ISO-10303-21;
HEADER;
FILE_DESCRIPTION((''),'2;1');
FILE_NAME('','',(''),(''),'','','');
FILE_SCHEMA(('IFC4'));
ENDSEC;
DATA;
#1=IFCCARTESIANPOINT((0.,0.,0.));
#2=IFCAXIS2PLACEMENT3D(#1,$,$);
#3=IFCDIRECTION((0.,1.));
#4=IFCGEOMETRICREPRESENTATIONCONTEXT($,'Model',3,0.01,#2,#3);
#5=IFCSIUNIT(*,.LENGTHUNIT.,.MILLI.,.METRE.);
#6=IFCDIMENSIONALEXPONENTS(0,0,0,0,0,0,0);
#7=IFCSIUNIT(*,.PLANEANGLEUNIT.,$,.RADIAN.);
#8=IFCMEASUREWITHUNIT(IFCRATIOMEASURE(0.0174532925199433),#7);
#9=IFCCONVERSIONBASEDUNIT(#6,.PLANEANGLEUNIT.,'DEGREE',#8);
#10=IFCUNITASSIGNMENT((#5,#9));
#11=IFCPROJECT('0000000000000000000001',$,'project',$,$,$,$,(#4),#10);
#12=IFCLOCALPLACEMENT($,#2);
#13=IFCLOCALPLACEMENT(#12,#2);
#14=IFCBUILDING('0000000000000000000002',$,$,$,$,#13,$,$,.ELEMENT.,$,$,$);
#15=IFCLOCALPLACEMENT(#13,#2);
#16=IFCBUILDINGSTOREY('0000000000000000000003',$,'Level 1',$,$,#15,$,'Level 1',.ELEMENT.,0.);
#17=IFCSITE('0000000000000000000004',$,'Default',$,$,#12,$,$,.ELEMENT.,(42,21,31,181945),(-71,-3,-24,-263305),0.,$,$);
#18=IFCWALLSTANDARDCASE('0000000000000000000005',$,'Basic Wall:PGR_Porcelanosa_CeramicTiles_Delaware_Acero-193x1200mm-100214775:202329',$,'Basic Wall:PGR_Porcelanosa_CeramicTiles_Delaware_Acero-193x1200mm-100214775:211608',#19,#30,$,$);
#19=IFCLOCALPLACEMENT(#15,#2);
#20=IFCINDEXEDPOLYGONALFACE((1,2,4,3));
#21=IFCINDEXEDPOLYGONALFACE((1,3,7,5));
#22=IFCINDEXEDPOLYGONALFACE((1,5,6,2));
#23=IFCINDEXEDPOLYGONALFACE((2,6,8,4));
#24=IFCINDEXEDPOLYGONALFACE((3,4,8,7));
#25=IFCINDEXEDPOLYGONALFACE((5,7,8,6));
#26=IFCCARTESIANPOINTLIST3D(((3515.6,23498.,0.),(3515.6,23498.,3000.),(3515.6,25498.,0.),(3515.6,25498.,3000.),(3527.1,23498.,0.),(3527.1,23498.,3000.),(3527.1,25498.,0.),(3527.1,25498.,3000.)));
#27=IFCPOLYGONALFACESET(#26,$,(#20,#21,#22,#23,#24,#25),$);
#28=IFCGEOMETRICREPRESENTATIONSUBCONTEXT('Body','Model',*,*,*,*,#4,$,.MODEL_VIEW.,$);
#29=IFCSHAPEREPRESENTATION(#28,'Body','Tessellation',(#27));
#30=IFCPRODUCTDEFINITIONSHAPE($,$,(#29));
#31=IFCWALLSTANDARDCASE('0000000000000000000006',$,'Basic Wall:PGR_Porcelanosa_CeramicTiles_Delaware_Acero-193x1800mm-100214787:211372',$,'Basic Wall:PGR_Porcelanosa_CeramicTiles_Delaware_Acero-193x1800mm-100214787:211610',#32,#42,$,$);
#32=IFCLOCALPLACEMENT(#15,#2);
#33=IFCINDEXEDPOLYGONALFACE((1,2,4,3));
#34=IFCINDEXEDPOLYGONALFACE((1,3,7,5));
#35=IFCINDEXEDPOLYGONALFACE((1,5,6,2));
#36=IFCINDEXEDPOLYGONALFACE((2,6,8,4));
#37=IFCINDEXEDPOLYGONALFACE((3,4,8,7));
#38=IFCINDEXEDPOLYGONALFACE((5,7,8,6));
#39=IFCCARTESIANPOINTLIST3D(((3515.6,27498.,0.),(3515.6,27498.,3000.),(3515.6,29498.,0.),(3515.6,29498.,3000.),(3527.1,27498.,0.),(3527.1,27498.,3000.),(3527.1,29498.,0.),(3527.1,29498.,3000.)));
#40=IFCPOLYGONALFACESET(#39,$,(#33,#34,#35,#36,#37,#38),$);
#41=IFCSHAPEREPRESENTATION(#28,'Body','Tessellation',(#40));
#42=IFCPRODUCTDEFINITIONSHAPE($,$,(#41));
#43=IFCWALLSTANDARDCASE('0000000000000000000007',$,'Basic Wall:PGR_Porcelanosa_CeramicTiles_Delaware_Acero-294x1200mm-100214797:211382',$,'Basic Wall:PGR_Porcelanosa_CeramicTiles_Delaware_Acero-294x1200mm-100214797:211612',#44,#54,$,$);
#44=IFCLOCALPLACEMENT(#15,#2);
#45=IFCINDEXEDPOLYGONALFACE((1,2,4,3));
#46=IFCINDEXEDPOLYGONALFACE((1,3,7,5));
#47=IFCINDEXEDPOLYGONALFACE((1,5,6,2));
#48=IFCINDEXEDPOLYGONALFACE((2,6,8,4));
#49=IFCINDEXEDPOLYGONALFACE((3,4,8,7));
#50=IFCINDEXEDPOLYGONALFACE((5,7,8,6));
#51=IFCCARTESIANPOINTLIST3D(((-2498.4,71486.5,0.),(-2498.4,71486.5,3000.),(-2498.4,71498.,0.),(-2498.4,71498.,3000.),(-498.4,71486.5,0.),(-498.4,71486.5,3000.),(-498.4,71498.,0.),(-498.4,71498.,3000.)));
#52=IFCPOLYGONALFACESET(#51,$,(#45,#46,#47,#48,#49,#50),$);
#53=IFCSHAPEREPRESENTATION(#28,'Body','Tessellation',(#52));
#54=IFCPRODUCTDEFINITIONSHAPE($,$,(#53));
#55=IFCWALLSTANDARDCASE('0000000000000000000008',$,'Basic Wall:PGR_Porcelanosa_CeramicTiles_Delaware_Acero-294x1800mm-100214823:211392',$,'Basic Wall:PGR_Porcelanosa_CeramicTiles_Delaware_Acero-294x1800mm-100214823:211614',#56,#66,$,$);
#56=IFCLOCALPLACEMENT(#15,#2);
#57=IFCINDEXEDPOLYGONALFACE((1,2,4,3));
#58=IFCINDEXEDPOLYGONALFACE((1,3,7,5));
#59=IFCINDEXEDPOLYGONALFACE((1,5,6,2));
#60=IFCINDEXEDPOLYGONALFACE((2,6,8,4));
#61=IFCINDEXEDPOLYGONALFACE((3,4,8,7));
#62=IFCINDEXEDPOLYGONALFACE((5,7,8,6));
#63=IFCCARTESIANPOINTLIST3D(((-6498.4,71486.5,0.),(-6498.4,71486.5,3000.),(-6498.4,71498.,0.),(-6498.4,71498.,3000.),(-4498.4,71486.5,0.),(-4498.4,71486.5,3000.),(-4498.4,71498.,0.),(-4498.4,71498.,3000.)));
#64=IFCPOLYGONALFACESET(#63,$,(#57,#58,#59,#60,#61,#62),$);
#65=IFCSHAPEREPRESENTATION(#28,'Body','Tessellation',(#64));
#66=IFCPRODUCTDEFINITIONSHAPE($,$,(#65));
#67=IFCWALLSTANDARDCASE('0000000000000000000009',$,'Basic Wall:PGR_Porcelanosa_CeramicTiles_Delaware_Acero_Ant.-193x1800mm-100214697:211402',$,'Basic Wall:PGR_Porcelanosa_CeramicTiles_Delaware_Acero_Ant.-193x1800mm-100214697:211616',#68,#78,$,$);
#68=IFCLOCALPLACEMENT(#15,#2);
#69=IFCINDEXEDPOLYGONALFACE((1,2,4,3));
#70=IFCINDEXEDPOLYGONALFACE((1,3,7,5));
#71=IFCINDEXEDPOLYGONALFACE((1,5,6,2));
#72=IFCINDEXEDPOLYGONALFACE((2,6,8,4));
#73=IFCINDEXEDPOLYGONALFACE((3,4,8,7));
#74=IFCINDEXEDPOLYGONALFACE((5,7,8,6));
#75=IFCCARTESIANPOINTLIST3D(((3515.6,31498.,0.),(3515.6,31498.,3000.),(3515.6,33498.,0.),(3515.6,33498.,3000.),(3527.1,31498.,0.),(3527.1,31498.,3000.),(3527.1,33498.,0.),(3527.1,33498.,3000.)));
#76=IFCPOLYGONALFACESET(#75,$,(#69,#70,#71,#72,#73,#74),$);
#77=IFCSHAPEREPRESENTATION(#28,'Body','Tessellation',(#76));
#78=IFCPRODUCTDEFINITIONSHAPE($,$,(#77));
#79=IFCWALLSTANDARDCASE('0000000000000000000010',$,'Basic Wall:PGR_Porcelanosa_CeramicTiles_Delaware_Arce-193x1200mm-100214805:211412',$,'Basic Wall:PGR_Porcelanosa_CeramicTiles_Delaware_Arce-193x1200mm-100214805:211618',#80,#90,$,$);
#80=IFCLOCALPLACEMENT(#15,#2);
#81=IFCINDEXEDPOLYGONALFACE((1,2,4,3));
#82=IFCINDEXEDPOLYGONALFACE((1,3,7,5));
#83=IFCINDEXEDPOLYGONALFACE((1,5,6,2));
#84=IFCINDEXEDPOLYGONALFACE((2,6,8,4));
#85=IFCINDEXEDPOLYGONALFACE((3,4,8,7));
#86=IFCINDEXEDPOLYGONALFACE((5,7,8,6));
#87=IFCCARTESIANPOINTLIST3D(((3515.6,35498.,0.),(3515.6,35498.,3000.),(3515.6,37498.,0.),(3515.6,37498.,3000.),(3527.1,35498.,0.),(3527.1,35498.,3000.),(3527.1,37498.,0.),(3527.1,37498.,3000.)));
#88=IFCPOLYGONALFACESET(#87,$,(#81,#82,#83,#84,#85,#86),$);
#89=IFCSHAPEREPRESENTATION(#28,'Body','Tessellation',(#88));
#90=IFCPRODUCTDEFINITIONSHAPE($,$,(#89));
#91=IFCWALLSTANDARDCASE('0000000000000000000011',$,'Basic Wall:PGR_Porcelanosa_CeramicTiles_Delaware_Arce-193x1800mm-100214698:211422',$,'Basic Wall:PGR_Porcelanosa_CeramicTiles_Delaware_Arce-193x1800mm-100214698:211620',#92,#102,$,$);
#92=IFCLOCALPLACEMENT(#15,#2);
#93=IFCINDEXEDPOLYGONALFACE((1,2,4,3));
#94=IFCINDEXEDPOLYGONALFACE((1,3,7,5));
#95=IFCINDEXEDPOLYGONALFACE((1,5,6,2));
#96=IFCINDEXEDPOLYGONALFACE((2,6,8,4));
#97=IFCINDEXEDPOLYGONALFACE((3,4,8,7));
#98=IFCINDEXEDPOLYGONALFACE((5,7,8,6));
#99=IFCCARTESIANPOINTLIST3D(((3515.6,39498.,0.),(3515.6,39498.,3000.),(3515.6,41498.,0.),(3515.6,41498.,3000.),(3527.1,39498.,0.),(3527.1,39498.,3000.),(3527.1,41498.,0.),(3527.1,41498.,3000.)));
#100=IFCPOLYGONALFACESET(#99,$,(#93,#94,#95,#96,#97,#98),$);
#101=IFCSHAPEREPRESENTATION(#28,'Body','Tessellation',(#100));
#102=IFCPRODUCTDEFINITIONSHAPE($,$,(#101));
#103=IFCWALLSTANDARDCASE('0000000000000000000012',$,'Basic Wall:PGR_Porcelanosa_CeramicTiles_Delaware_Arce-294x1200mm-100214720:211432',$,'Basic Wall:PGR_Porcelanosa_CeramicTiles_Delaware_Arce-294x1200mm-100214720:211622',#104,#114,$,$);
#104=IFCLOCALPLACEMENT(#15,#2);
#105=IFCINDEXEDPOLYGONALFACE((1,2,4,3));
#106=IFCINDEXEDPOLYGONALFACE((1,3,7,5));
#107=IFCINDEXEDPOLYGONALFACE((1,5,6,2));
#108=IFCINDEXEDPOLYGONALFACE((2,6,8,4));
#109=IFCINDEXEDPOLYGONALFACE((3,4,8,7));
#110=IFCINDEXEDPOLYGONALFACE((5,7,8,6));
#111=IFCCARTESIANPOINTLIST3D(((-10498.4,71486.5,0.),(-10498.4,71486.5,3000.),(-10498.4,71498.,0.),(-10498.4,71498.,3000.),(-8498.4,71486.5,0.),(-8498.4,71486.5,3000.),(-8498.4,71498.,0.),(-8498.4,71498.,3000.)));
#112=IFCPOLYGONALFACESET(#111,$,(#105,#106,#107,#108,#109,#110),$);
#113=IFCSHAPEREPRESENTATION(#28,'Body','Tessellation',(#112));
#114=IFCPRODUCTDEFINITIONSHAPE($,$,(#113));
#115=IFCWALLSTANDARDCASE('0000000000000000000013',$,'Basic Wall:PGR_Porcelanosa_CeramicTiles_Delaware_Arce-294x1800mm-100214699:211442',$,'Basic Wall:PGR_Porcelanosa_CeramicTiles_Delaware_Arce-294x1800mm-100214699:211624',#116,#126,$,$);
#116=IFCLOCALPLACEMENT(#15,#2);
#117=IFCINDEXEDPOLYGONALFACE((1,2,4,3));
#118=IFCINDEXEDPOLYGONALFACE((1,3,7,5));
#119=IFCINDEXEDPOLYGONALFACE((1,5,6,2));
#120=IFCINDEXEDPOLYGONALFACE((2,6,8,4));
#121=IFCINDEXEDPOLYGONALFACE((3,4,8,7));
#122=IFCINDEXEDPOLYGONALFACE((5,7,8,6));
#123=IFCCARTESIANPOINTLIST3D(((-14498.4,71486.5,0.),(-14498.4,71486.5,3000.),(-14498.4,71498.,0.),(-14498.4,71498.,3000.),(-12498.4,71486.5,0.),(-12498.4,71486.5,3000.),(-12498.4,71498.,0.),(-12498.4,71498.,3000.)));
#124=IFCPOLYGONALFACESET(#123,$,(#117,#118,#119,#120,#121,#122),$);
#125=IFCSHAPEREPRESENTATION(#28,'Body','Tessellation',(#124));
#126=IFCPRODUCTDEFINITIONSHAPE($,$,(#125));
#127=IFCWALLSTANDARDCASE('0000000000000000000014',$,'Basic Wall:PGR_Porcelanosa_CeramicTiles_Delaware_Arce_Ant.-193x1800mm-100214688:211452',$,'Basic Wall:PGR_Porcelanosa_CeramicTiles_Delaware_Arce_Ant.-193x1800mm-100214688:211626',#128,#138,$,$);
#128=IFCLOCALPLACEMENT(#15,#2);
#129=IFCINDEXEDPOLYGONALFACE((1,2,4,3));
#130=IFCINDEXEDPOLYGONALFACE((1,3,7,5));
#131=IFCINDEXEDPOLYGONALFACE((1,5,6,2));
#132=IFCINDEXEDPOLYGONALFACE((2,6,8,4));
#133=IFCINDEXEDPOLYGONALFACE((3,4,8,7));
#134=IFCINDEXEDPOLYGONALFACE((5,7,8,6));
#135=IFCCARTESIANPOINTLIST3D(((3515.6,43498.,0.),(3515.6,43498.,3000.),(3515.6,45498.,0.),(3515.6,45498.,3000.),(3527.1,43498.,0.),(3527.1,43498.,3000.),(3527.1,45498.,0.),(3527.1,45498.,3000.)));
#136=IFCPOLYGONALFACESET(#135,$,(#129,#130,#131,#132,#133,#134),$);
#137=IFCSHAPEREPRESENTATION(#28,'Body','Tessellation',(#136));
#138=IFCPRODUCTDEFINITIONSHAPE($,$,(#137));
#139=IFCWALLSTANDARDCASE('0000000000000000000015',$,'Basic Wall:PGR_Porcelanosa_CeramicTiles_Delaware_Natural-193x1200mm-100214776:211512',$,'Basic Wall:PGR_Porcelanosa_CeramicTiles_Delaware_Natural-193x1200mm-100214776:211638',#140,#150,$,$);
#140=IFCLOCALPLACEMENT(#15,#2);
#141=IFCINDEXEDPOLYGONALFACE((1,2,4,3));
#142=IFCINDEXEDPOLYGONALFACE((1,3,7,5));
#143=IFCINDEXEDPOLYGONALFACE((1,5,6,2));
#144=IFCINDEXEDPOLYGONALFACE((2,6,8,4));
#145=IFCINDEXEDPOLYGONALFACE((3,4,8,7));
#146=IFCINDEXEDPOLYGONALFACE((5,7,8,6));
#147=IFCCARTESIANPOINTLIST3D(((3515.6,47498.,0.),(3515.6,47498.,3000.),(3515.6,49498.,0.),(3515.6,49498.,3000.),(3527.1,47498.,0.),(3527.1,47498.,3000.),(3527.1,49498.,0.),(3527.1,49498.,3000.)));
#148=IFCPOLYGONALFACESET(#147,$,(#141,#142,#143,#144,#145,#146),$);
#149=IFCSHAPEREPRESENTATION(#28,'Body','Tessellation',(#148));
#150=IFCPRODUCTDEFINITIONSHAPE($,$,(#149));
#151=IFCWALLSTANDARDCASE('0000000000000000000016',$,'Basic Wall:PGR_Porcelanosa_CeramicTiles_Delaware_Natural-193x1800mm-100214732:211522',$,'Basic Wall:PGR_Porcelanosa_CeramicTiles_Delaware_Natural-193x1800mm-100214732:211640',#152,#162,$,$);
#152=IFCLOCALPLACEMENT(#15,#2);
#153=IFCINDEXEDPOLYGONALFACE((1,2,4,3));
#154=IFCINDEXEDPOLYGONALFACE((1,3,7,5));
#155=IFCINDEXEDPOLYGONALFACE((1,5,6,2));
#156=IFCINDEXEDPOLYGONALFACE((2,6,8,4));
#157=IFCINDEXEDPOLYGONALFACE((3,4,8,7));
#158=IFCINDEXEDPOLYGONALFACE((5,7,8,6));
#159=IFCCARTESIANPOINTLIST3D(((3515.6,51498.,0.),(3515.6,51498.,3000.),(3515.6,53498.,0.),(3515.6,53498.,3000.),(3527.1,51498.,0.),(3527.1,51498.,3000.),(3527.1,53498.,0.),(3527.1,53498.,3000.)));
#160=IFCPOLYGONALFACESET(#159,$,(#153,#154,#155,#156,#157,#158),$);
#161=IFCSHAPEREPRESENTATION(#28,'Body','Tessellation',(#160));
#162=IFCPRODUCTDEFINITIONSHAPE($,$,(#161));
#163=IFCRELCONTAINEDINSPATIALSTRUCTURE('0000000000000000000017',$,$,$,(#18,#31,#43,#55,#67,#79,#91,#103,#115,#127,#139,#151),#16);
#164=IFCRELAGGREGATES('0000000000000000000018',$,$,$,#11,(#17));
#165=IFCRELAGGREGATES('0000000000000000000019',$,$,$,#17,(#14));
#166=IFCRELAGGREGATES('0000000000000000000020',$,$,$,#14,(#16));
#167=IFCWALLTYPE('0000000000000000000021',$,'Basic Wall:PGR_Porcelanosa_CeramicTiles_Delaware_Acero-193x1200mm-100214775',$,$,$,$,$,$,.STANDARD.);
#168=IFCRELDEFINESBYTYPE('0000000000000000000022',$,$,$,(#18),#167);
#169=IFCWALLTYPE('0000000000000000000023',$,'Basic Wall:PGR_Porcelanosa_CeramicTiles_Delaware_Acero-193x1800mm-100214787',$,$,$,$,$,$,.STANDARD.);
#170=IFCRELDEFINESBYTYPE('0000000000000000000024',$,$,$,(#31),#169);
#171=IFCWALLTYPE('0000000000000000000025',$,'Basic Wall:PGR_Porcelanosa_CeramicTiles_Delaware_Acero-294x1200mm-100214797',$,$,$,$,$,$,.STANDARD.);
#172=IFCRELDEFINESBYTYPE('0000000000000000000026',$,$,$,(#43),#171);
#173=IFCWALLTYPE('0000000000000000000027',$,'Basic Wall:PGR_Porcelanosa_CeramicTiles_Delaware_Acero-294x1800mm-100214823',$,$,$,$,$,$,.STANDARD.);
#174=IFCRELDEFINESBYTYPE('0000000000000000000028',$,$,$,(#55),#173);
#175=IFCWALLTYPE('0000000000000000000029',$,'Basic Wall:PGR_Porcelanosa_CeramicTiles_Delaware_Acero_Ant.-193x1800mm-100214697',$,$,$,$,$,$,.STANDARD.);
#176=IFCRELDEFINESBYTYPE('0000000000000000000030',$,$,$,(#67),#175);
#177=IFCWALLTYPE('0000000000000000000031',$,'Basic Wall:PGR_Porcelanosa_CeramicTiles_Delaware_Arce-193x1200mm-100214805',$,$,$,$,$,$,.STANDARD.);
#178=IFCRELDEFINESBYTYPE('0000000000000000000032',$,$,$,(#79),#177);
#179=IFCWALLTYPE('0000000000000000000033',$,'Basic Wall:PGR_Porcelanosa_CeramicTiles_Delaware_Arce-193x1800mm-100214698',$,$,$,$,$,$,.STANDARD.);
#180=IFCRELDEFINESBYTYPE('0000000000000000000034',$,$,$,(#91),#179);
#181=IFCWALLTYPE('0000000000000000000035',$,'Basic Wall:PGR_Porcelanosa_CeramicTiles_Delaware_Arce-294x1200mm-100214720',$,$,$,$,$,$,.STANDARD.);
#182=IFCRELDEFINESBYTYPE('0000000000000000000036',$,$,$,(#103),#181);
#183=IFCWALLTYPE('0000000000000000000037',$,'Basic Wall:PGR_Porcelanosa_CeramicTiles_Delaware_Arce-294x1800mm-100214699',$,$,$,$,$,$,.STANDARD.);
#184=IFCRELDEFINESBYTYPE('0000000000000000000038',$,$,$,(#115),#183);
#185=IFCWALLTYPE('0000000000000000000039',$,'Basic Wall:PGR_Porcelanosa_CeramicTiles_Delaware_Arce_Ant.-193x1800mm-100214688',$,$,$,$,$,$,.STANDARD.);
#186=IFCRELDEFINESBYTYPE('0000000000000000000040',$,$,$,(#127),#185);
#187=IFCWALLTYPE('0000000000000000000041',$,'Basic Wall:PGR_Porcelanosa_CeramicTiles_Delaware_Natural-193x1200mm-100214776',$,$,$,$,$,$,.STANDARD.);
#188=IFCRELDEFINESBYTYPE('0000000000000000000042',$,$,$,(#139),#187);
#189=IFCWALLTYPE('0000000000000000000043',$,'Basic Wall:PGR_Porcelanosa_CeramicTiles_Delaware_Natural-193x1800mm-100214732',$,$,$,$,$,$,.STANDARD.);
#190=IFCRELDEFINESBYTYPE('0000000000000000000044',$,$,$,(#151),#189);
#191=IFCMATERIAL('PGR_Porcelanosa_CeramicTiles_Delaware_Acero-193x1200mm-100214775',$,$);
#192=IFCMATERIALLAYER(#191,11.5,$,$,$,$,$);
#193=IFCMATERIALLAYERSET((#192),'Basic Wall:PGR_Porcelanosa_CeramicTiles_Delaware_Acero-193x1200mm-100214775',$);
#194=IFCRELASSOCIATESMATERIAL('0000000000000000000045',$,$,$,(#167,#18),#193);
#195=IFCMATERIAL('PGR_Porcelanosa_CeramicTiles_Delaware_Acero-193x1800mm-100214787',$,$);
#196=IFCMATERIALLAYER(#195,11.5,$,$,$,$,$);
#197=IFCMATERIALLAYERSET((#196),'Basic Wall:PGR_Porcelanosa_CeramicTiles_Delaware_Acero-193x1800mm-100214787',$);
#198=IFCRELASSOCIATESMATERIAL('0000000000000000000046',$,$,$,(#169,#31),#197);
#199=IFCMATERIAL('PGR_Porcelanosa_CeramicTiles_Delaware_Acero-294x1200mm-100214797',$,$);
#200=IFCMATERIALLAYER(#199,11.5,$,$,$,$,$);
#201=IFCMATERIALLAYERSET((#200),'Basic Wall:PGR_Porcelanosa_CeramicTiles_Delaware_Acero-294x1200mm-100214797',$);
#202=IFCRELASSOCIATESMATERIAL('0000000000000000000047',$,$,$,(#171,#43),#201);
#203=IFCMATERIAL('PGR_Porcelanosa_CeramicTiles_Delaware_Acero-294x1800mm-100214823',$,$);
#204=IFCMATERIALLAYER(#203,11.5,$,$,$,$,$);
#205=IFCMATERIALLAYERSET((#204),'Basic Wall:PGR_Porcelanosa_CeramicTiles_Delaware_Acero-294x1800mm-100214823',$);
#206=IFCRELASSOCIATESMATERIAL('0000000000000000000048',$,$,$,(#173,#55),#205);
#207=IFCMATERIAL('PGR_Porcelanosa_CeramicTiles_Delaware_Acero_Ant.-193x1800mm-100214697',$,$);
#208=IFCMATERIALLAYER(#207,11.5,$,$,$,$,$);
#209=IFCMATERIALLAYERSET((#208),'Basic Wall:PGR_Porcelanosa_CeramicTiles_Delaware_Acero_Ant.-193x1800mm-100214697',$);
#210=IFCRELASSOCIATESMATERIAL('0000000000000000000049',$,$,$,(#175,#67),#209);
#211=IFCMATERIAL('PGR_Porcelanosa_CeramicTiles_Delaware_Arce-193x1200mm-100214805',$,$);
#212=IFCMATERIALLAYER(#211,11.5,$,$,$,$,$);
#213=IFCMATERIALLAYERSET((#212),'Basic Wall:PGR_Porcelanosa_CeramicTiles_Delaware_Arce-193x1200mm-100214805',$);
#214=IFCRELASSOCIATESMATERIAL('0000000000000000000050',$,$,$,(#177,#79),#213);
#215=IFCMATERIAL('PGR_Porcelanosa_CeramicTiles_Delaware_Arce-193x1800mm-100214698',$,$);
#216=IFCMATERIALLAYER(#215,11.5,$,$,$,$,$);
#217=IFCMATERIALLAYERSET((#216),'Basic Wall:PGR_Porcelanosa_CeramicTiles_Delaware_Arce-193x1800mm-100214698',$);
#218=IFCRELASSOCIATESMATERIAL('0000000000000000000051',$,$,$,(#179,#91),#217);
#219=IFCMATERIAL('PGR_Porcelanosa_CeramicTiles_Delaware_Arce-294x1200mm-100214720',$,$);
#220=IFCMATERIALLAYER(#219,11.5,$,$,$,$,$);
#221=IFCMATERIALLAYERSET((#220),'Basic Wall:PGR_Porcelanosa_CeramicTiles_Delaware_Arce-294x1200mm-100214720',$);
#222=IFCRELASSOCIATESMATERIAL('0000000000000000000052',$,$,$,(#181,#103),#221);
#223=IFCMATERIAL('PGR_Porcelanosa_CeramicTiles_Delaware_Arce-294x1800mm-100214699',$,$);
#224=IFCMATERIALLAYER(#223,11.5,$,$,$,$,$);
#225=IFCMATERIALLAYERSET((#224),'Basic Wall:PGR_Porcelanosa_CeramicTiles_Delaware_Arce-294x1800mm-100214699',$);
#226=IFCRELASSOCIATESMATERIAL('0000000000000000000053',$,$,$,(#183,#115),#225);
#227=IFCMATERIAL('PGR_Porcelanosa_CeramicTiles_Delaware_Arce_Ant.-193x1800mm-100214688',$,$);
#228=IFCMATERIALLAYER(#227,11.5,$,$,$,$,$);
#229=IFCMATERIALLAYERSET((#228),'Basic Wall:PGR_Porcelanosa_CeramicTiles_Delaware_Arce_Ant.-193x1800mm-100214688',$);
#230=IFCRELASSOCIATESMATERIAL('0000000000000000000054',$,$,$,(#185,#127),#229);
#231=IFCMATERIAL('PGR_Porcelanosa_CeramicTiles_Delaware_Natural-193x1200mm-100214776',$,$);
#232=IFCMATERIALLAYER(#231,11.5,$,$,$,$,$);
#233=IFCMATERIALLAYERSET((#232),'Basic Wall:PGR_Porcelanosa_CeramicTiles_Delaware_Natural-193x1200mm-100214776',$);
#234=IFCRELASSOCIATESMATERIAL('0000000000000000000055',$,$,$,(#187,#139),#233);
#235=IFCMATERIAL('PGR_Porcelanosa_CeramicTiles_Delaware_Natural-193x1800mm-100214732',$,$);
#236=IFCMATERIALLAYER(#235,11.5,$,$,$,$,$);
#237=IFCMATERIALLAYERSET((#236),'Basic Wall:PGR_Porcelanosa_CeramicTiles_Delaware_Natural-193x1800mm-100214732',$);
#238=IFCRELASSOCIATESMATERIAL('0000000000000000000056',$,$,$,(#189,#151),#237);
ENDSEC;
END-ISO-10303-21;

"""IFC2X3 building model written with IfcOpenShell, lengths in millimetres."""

from ifc_helpers import new_model, entity, si_unit, converted_unit, direction, frame, frame_2d, origin, place, context, subcontext, project, spatial, rectangle, extrude, material, layer, layer_set, layer_usage, type_object, element, save


model = new_model("IFC2X3")

# Units and contexts
model_context = context("Model", 3, precision=0.01, world=origin(), true_north=direction((0.0, 1.0)))
body_context = subcontext(model_context, "Body", "Model", "MODEL_VIEW")
ifc_project = project(units=[si_unit("LENGTHUNIT", "METRE", prefix="MILLI"), converted_unit("PLANEANGLEUNIT", "DEGREE", entity("IfcRatioMeasure", 0.0174532925199433), si_unit("PLANEANGLEUNIT", "RADIAN"), dimensions=[0, 0, 0, 0, 0, 0, 0])], contexts=[model_context])

# Site, building, storey
site_placement = place(None, origin())
site = spatial("IfcSite", under=ifc_project, at=site_placement, Name="Default", CompositionType="ELEMENT", RefLatitude=(42, 21, 31, 181945), RefLongitude=(-71, -3, -24, -263305), RefElevation=0.0)
building_placement = place(site_placement, origin())
building = spatial("IfcBuilding", under=site, at=building_placement, CompositionType="ELEMENT")
storey_placement = place(building_placement, origin())
storey = spatial("IfcBuildingStorey", under=building, at=storey_placement, Name="Level 1", LongName="Level 1", CompositionType="ELEMENT", Elevation=0.0)

# Walls
ifc_material_1 = material(Name="PGR_Porcelanosa_CeramicTiles_Delaware_Acero-193x1200mm-100214775")
ifc_layer_1 = layer(ifc_material_1, 11.5)
ifc_layer_set_1 = layer_set([ifc_layer_1], Name="Basic Wall:PGR_Porcelanosa_CeramicTiles_Delaware_Acero-193x1200mm-100214775")
ifc_layer_usage_1 = layer_usage(ifc_layer_set_1, "AXIS2", "POSITIVE", -5.8)
wall_type_1 = type_object("IfcWallType", Name="Basic Wall:PGR_Porcelanosa_CeramicTiles_Delaware_Acero-193x1200mm-100214775", PredefinedType="STANDARD", material=ifc_layer_set_1)
wall_1_placement = place(storey_placement, frame((3521.3, 25498.0, 0.0), z_axis=(0.0, 0.0, 1.0), x_axis=(0.0, -1.0, 0.0)))
element("IfcWallStandardCase", 1, at=wall_1_placement, inside=storey, type_object=wall_type_1, material=ifc_layer_usage_1, Name="Basic Wall:PGR_Porcelanosa_CeramicTiles_Delaware_Acero-193x1200mm-100214775:202329", ObjectType="Basic Wall:PGR_Porcelanosa_CeramicTiles_Delaware_Acero-193x1200mm-100214775:211608", context=body_context, shape_type="SweptSolid", body=[
    extrude(rectangle(XDim=2000.0, YDim=11.5, at=frame_2d((1000.0, 0.0), x_axis=(-1.0, 0.0))), origin(), (0.0, 0.0, 1.0), 3000.0),
])
ifc_material_2 = material(Name="PGR_Porcelanosa_CeramicTiles_Delaware_Acero-193x1800mm-100214787")
ifc_layer_2 = layer(ifc_material_2, 11.5)
ifc_layer_set_2 = layer_set([ifc_layer_2], Name="Basic Wall:PGR_Porcelanosa_CeramicTiles_Delaware_Acero-193x1800mm-100214787")
ifc_layer_usage_2 = layer_usage(ifc_layer_set_2, "AXIS2", "POSITIVE", -5.8)
wall_type_2 = type_object("IfcWallType", Name="Basic Wall:PGR_Porcelanosa_CeramicTiles_Delaware_Acero-193x1800mm-100214787", PredefinedType="STANDARD", material=ifc_layer_set_2)
wall_2_placement = place(storey_placement, frame((3521.3, 29498.0, 0.0), z_axis=(0.0, 0.0, 1.0), x_axis=(0.0, -1.0, 0.0)))
element("IfcWallStandardCase", 2, at=wall_2_placement, inside=storey, type_object=wall_type_2, material=ifc_layer_usage_2, Name="Basic Wall:PGR_Porcelanosa_CeramicTiles_Delaware_Acero-193x1800mm-100214787:211372", ObjectType="Basic Wall:PGR_Porcelanosa_CeramicTiles_Delaware_Acero-193x1800mm-100214787:211610", context=body_context, shape_type="SweptSolid", body=[
    extrude(rectangle(XDim=2000.0, YDim=11.5, at=frame_2d((1000.0, 0.0), x_axis=(-1.0, 0.0))), origin(), (0.0, 0.0, 1.0), 3000.0),
])
ifc_material_3 = material(Name="PGR_Porcelanosa_CeramicTiles_Delaware_Acero-294x1200mm-100214797")
ifc_layer_3 = layer(ifc_material_3, 11.5)
ifc_layer_set_3 = layer_set([ifc_layer_3], Name="Basic Wall:PGR_Porcelanosa_CeramicTiles_Delaware_Acero-294x1200mm-100214797")
ifc_layer_usage_3 = layer_usage(ifc_layer_set_3, "AXIS2", "POSITIVE", -5.8)
wall_type_3 = type_object("IfcWallType", Name="Basic Wall:PGR_Porcelanosa_CeramicTiles_Delaware_Acero-294x1200mm-100214797", PredefinedType="STANDARD", material=ifc_layer_set_3)
wall_3_placement = place(storey_placement, frame((-2498.4, 71492.3, 0.0)))
element("IfcWallStandardCase", 3, at=wall_3_placement, inside=storey, type_object=wall_type_3, material=ifc_layer_usage_3, Name="Basic Wall:PGR_Porcelanosa_CeramicTiles_Delaware_Acero-294x1200mm-100214797:211382", ObjectType="Basic Wall:PGR_Porcelanosa_CeramicTiles_Delaware_Acero-294x1200mm-100214797:211612", context=body_context, shape_type="SweptSolid", body=[
    extrude(rectangle(XDim=2000.0, YDim=11.5, at=frame_2d((1000.0, 0.0), x_axis=(-1.0, 0.0))), origin(), (0.0, 0.0, 1.0), 3000.0),
])
ifc_material_4 = material(Name="PGR_Porcelanosa_CeramicTiles_Delaware_Acero-294x1800mm-100214823")
ifc_layer_4 = layer(ifc_material_4, 11.5)
ifc_layer_set_4 = layer_set([ifc_layer_4], Name="Basic Wall:PGR_Porcelanosa_CeramicTiles_Delaware_Acero-294x1800mm-100214823")
ifc_layer_usage_4 = layer_usage(ifc_layer_set_4, "AXIS2", "POSITIVE", -5.8)
wall_type_4 = type_object("IfcWallType", Name="Basic Wall:PGR_Porcelanosa_CeramicTiles_Delaware_Acero-294x1800mm-100214823", PredefinedType="STANDARD", material=ifc_layer_set_4)
wall_4_placement = place(storey_placement, frame((-6498.4, 71492.3, 0.0)))
element("IfcWallStandardCase", 4, at=wall_4_placement, inside=storey, type_object=wall_type_4, material=ifc_layer_usage_4, Name="Basic Wall:PGR_Porcelanosa_CeramicTiles_Delaware_Acero-294x1800mm-100214823:211392", ObjectType="Basic Wall:PGR_Porcelanosa_CeramicTiles_Delaware_Acero-294x1800mm-100214823:211614", context=body_context, shape_type="SweptSolid", body=[
    extrude(rectangle(XDim=2000.0, YDim=11.5, at=frame_2d((1000.0, 0.0), x_axis=(-1.0, 0.0))), origin(), (0.0, 0.0, 1.0), 3000.0),
])
ifc_material_5 = material(Name="PGR_Porcelanosa_CeramicTiles_Delaware_Acero_Ant.-193x1800mm-100214697")
ifc_layer_5 = layer(ifc_material_5, 11.5)
ifc_layer_set_5 = layer_set([ifc_layer_5], Name="Basic Wall:PGR_Porcelanosa_CeramicTiles_Delaware_Acero_Ant.-193x1800mm-100214697")
ifc_layer_usage_5 = layer_usage(ifc_layer_set_5, "AXIS2", "POSITIVE", -5.8)
wall_type_5 = type_object("IfcWallType", Name="Basic Wall:PGR_Porcelanosa_CeramicTiles_Delaware_Acero_Ant.-193x1800mm-100214697", PredefinedType="STANDARD", material=ifc_layer_set_5)
wall_5_placement = place(storey_placement, frame((3521.3, 33498.0, 0.0), z_axis=(0.0, 0.0, 1.0), x_axis=(0.0, -1.0, 0.0)))
element("IfcWallStandardCase", 5, at=wall_5_placement, inside=storey, type_object=wall_type_5, material=ifc_layer_usage_5, Name="Basic Wall:PGR_Porcelanosa_CeramicTiles_Delaware_Acero_Ant.-193x1800mm-100214697:211402", ObjectType="Basic Wall:PGR_Porcelanosa_CeramicTiles_Delaware_Acero_Ant.-193x1800mm-100214697:211616", context=body_context, shape_type="SweptSolid", body=[
    extrude(rectangle(XDim=2000.0, YDim=11.5, at=frame_2d((1000.0, 0.0), x_axis=(-1.0, 0.0))), origin(), (0.0, 0.0, 1.0), 3000.0),
])
ifc_material_6 = material(Name="PGR_Porcelanosa_CeramicTiles_Delaware_Arce-193x1200mm-100214805")
ifc_layer_6 = layer(ifc_material_6, 11.5)
ifc_layer_set_6 = layer_set([ifc_layer_6], Name="Basic Wall:PGR_Porcelanosa_CeramicTiles_Delaware_Arce-193x1200mm-100214805")
ifc_layer_usage_6 = layer_usage(ifc_layer_set_6, "AXIS2", "POSITIVE", -5.8)
wall_type_6 = type_object("IfcWallType", Name="Basic Wall:PGR_Porcelanosa_CeramicTiles_Delaware_Arce-193x1200mm-100214805", PredefinedType="STANDARD", material=ifc_layer_set_6)
wall_6_placement = place(storey_placement, frame((3521.3, 37498.0, 0.0), z_axis=(0.0, 0.0, 1.0), x_axis=(0.0, -1.0, 0.0)))
element("IfcWallStandardCase", 6, at=wall_6_placement, inside=storey, type_object=wall_type_6, material=ifc_layer_usage_6, Name="Basic Wall:PGR_Porcelanosa_CeramicTiles_Delaware_Arce-193x1200mm-100214805:211412", ObjectType="Basic Wall:PGR_Porcelanosa_CeramicTiles_Delaware_Arce-193x1200mm-100214805:211618", context=body_context, shape_type="SweptSolid", body=[
    extrude(rectangle(XDim=2000.0, YDim=11.5, at=frame_2d((1000.0, 0.0), x_axis=(-1.0, 0.0))), origin(), (0.0, 0.0, 1.0), 3000.0),
])
ifc_material_7 = material(Name="PGR_Porcelanosa_CeramicTiles_Delaware_Arce-193x1800mm-100214698")
ifc_layer_7 = layer(ifc_material_7, 11.5)
ifc_layer_set_7 = layer_set([ifc_layer_7], Name="Basic Wall:PGR_Porcelanosa_CeramicTiles_Delaware_Arce-193x1800mm-100214698")
ifc_layer_usage_7 = layer_usage(ifc_layer_set_7, "AXIS2", "POSITIVE", -5.8)
wall_type_7 = type_object("IfcWallType", Name="Basic Wall:PGR_Porcelanosa_CeramicTiles_Delaware_Arce-193x1800mm-100214698", PredefinedType="STANDARD", material=ifc_layer_set_7)
wall_7_placement = place(storey_placement, frame((3521.3, 41498.0, 0.0), z_axis=(0.0, 0.0, 1.0), x_axis=(0.0, -1.0, 0.0)))
element("IfcWallStandardCase", 7, at=wall_7_placement, inside=storey, type_object=wall_type_7, material=ifc_layer_usage_7, Name="Basic Wall:PGR_Porcelanosa_CeramicTiles_Delaware_Arce-193x1800mm-100214698:211422", ObjectType="Basic Wall:PGR_Porcelanosa_CeramicTiles_Delaware_Arce-193x1800mm-100214698:211620", context=body_context, shape_type="SweptSolid", body=[
    extrude(rectangle(XDim=2000.0, YDim=11.5, at=frame_2d((1000.0, 0.0), x_axis=(-1.0, 0.0))), origin(), (0.0, 0.0, 1.0), 3000.0),
])
ifc_material_8 = material(Name="PGR_Porcelanosa_CeramicTiles_Delaware_Arce-294x1200mm-100214720")
ifc_layer_8 = layer(ifc_material_8, 11.5)
ifc_layer_set_8 = layer_set([ifc_layer_8], Name="Basic Wall:PGR_Porcelanosa_CeramicTiles_Delaware_Arce-294x1200mm-100214720")
ifc_layer_usage_8 = layer_usage(ifc_layer_set_8, "AXIS2", "POSITIVE", -5.8)
wall_type_8 = type_object("IfcWallType", Name="Basic Wall:PGR_Porcelanosa_CeramicTiles_Delaware_Arce-294x1200mm-100214720", PredefinedType="STANDARD", material=ifc_layer_set_8)
wall_8_placement = place(storey_placement, frame((-10498.4, 71492.3, 0.0)))
element("IfcWallStandardCase", 8, at=wall_8_placement, inside=storey, type_object=wall_type_8, material=ifc_layer_usage_8, Name="Basic Wall:PGR_Porcelanosa_CeramicTiles_Delaware_Arce-294x1200mm-100214720:211432", ObjectType="Basic Wall:PGR_Porcelanosa_CeramicTiles_Delaware_Arce-294x1200mm-100214720:211622", context=body_context, shape_type="SweptSolid", body=[
    extrude(rectangle(XDim=2000.0, YDim=11.5, at=frame_2d((1000.0, 0.0), x_axis=(-1.0, 0.0))), origin(), (0.0, 0.0, 1.0), 3000.0),
])
ifc_material_9 = material(Name="PGR_Porcelanosa_CeramicTiles_Delaware_Arce-294x1800mm-100214699")
ifc_layer_9 = layer(ifc_material_9, 11.5)
ifc_layer_set_9 = layer_set([ifc_layer_9], Name="Basic Wall:PGR_Porcelanosa_CeramicTiles_Delaware_Arce-294x1800mm-100214699")
ifc_layer_usage_9 = layer_usage(ifc_layer_set_9, "AXIS2", "POSITIVE", -5.8)
wall_type_9 = type_object("IfcWallType", Name="Basic Wall:PGR_Porcelanosa_CeramicTiles_Delaware_Arce-294x1800mm-100214699", PredefinedType="STANDARD", material=ifc_layer_set_9)
wall_9_placement = place(storey_placement, frame((-14498.4, 71492.3, 0.0)))
element("IfcWallStandardCase", 9, at=wall_9_placement, inside=storey, type_object=wall_type_9, material=ifc_layer_usage_9, Name="Basic Wall:PGR_Porcelanosa_CeramicTiles_Delaware_Arce-294x1800mm-100214699:211442", ObjectType="Basic Wall:PGR_Porcelanosa_CeramicTiles_Delaware_Arce-294x1800mm-100214699:211624", context=body_context, shape_type="SweptSolid", body=[
    extrude(rectangle(XDim=2000.0, YDim=11.5, at=frame_2d((1000.0, 0.0), x_axis=(-1.0, 0.0))), origin(), (0.0, 0.0, 1.0), 3000.0),
])
ifc_material_10 = material(Name="PGR_Porcelanosa_CeramicTiles_Delaware_Arce_Ant.-193x1800mm-100214688")
ifc_layer_10 = layer(ifc_material_10, 11.5)
ifc_layer_set_10 = layer_set([ifc_layer_10], Name="Basic Wall:PGR_Porcelanosa_CeramicTiles_Delaware_Arce_Ant.-193x1800mm-100214688")
ifc_layer_usage_10 = layer_usage(ifc_layer_set_10, "AXIS2", "POSITIVE", -5.8)
wall_type_10 = type_object("IfcWallType", Name="Basic Wall:PGR_Porcelanosa_CeramicTiles_Delaware_Arce_Ant.-193x1800mm-100214688", PredefinedType="STANDARD", material=ifc_layer_set_10)
wall_10_placement = place(storey_placement, frame((3521.3, 45498.0, 0.0), z_axis=(0.0, 0.0, 1.0), x_axis=(0.0, -1.0, 0.0)))
element("IfcWallStandardCase", 10, at=wall_10_placement, inside=storey, type_object=wall_type_10, material=ifc_layer_usage_10, Name="Basic Wall:PGR_Porcelanosa_CeramicTiles_Delaware_Arce_Ant.-193x1800mm-100214688:211452", ObjectType="Basic Wall:PGR_Porcelanosa_CeramicTiles_Delaware_Arce_Ant.-193x1800mm-100214688:211626", context=body_context, shape_type="SweptSolid", body=[
    extrude(rectangle(XDim=2000.0, YDim=11.5, at=frame_2d((1000.0, 0.0), x_axis=(-1.0, 0.0))), origin(), (0.0, 0.0, 1.0), 3000.0),
])
ifc_material_11 = material(Name="PGR_Porcelanosa_CeramicTiles_Delaware_Natural-193x1200mm-100214776")
ifc_layer_11 = layer(ifc_material_11, 11.5)
ifc_layer_set_11 = layer_set([ifc_layer_11], Name="Basic Wall:PGR_Porcelanosa_CeramicTiles_Delaware_Natural-193x1200mm-100214776")
ifc_layer_usage_11 = layer_usage(ifc_layer_set_11, "AXIS2", "POSITIVE", -5.8)
wall_type_11 = type_object("IfcWallType", Name="Basic Wall:PGR_Porcelanosa_CeramicTiles_Delaware_Natural-193x1200mm-100214776", PredefinedType="STANDARD", material=ifc_layer_set_11)
wall_11_placement = place(storey_placement, frame((3521.3, 49498.0, 0.0), z_axis=(0.0, 0.0, 1.0), x_axis=(0.0, -1.0, 0.0)))
element("IfcWallStandardCase", 11, at=wall_11_placement, inside=storey, type_object=wall_type_11, material=ifc_layer_usage_11, Name="Basic Wall:PGR_Porcelanosa_CeramicTiles_Delaware_Natural-193x1200mm-100214776:211512", ObjectType="Basic Wall:PGR_Porcelanosa_CeramicTiles_Delaware_Natural-193x1200mm-100214776:211638", context=body_context, shape_type="SweptSolid", body=[
    extrude(rectangle(XDim=2000.0, YDim=11.5, at=frame_2d((1000.0, 0.0), x_axis=(-1.0, 0.0))), origin(), (0.0, 0.0, 1.0), 3000.0),
])
ifc_material_12 = material(Name="PGR_Porcelanosa_CeramicTiles_Delaware_Natural-193x1800mm-100214732")
ifc_layer_12 = layer(ifc_material_12, 11.5)
ifc_layer_set_12 = layer_set([ifc_layer_12], Name="Basic Wall:PGR_Porcelanosa_CeramicTiles_Delaware_Natural-193x1800mm-100214732")
ifc_layer_usage_12 = layer_usage(ifc_layer_set_12, "AXIS2", "POSITIVE", -5.8)
wall_type_12 = type_object("IfcWallType", Name="Basic Wall:PGR_Porcelanosa_CeramicTiles_Delaware_Natural-193x1800mm-100214732", PredefinedType="STANDARD", material=ifc_layer_set_12)
wall_12_placement = place(storey_placement, frame((3521.3, 53498.0, 0.0), z_axis=(0.0, 0.0, 1.0), x_axis=(0.0, -1.0, 0.0)))
element("IfcWallStandardCase", 12, at=wall_12_placement, inside=storey, type_object=wall_type_12, material=ifc_layer_usage_12, Name="Basic Wall:PGR_Porcelanosa_CeramicTiles_Delaware_Natural-193x1800mm-100214732:211522", ObjectType="Basic Wall:PGR_Porcelanosa_CeramicTiles_Delaware_Natural-193x1800mm-100214732:211640", context=body_context, shape_type="SweptSolid", body=[
    extrude(rectangle(XDim=2000.0, YDim=11.5, at=frame_2d((1000.0, 0.0), x_axis=(-1.0, 0.0))), origin(), (0.0, 0.0, 1.0), 3000.0),
])

save(model, "model.ifc")
